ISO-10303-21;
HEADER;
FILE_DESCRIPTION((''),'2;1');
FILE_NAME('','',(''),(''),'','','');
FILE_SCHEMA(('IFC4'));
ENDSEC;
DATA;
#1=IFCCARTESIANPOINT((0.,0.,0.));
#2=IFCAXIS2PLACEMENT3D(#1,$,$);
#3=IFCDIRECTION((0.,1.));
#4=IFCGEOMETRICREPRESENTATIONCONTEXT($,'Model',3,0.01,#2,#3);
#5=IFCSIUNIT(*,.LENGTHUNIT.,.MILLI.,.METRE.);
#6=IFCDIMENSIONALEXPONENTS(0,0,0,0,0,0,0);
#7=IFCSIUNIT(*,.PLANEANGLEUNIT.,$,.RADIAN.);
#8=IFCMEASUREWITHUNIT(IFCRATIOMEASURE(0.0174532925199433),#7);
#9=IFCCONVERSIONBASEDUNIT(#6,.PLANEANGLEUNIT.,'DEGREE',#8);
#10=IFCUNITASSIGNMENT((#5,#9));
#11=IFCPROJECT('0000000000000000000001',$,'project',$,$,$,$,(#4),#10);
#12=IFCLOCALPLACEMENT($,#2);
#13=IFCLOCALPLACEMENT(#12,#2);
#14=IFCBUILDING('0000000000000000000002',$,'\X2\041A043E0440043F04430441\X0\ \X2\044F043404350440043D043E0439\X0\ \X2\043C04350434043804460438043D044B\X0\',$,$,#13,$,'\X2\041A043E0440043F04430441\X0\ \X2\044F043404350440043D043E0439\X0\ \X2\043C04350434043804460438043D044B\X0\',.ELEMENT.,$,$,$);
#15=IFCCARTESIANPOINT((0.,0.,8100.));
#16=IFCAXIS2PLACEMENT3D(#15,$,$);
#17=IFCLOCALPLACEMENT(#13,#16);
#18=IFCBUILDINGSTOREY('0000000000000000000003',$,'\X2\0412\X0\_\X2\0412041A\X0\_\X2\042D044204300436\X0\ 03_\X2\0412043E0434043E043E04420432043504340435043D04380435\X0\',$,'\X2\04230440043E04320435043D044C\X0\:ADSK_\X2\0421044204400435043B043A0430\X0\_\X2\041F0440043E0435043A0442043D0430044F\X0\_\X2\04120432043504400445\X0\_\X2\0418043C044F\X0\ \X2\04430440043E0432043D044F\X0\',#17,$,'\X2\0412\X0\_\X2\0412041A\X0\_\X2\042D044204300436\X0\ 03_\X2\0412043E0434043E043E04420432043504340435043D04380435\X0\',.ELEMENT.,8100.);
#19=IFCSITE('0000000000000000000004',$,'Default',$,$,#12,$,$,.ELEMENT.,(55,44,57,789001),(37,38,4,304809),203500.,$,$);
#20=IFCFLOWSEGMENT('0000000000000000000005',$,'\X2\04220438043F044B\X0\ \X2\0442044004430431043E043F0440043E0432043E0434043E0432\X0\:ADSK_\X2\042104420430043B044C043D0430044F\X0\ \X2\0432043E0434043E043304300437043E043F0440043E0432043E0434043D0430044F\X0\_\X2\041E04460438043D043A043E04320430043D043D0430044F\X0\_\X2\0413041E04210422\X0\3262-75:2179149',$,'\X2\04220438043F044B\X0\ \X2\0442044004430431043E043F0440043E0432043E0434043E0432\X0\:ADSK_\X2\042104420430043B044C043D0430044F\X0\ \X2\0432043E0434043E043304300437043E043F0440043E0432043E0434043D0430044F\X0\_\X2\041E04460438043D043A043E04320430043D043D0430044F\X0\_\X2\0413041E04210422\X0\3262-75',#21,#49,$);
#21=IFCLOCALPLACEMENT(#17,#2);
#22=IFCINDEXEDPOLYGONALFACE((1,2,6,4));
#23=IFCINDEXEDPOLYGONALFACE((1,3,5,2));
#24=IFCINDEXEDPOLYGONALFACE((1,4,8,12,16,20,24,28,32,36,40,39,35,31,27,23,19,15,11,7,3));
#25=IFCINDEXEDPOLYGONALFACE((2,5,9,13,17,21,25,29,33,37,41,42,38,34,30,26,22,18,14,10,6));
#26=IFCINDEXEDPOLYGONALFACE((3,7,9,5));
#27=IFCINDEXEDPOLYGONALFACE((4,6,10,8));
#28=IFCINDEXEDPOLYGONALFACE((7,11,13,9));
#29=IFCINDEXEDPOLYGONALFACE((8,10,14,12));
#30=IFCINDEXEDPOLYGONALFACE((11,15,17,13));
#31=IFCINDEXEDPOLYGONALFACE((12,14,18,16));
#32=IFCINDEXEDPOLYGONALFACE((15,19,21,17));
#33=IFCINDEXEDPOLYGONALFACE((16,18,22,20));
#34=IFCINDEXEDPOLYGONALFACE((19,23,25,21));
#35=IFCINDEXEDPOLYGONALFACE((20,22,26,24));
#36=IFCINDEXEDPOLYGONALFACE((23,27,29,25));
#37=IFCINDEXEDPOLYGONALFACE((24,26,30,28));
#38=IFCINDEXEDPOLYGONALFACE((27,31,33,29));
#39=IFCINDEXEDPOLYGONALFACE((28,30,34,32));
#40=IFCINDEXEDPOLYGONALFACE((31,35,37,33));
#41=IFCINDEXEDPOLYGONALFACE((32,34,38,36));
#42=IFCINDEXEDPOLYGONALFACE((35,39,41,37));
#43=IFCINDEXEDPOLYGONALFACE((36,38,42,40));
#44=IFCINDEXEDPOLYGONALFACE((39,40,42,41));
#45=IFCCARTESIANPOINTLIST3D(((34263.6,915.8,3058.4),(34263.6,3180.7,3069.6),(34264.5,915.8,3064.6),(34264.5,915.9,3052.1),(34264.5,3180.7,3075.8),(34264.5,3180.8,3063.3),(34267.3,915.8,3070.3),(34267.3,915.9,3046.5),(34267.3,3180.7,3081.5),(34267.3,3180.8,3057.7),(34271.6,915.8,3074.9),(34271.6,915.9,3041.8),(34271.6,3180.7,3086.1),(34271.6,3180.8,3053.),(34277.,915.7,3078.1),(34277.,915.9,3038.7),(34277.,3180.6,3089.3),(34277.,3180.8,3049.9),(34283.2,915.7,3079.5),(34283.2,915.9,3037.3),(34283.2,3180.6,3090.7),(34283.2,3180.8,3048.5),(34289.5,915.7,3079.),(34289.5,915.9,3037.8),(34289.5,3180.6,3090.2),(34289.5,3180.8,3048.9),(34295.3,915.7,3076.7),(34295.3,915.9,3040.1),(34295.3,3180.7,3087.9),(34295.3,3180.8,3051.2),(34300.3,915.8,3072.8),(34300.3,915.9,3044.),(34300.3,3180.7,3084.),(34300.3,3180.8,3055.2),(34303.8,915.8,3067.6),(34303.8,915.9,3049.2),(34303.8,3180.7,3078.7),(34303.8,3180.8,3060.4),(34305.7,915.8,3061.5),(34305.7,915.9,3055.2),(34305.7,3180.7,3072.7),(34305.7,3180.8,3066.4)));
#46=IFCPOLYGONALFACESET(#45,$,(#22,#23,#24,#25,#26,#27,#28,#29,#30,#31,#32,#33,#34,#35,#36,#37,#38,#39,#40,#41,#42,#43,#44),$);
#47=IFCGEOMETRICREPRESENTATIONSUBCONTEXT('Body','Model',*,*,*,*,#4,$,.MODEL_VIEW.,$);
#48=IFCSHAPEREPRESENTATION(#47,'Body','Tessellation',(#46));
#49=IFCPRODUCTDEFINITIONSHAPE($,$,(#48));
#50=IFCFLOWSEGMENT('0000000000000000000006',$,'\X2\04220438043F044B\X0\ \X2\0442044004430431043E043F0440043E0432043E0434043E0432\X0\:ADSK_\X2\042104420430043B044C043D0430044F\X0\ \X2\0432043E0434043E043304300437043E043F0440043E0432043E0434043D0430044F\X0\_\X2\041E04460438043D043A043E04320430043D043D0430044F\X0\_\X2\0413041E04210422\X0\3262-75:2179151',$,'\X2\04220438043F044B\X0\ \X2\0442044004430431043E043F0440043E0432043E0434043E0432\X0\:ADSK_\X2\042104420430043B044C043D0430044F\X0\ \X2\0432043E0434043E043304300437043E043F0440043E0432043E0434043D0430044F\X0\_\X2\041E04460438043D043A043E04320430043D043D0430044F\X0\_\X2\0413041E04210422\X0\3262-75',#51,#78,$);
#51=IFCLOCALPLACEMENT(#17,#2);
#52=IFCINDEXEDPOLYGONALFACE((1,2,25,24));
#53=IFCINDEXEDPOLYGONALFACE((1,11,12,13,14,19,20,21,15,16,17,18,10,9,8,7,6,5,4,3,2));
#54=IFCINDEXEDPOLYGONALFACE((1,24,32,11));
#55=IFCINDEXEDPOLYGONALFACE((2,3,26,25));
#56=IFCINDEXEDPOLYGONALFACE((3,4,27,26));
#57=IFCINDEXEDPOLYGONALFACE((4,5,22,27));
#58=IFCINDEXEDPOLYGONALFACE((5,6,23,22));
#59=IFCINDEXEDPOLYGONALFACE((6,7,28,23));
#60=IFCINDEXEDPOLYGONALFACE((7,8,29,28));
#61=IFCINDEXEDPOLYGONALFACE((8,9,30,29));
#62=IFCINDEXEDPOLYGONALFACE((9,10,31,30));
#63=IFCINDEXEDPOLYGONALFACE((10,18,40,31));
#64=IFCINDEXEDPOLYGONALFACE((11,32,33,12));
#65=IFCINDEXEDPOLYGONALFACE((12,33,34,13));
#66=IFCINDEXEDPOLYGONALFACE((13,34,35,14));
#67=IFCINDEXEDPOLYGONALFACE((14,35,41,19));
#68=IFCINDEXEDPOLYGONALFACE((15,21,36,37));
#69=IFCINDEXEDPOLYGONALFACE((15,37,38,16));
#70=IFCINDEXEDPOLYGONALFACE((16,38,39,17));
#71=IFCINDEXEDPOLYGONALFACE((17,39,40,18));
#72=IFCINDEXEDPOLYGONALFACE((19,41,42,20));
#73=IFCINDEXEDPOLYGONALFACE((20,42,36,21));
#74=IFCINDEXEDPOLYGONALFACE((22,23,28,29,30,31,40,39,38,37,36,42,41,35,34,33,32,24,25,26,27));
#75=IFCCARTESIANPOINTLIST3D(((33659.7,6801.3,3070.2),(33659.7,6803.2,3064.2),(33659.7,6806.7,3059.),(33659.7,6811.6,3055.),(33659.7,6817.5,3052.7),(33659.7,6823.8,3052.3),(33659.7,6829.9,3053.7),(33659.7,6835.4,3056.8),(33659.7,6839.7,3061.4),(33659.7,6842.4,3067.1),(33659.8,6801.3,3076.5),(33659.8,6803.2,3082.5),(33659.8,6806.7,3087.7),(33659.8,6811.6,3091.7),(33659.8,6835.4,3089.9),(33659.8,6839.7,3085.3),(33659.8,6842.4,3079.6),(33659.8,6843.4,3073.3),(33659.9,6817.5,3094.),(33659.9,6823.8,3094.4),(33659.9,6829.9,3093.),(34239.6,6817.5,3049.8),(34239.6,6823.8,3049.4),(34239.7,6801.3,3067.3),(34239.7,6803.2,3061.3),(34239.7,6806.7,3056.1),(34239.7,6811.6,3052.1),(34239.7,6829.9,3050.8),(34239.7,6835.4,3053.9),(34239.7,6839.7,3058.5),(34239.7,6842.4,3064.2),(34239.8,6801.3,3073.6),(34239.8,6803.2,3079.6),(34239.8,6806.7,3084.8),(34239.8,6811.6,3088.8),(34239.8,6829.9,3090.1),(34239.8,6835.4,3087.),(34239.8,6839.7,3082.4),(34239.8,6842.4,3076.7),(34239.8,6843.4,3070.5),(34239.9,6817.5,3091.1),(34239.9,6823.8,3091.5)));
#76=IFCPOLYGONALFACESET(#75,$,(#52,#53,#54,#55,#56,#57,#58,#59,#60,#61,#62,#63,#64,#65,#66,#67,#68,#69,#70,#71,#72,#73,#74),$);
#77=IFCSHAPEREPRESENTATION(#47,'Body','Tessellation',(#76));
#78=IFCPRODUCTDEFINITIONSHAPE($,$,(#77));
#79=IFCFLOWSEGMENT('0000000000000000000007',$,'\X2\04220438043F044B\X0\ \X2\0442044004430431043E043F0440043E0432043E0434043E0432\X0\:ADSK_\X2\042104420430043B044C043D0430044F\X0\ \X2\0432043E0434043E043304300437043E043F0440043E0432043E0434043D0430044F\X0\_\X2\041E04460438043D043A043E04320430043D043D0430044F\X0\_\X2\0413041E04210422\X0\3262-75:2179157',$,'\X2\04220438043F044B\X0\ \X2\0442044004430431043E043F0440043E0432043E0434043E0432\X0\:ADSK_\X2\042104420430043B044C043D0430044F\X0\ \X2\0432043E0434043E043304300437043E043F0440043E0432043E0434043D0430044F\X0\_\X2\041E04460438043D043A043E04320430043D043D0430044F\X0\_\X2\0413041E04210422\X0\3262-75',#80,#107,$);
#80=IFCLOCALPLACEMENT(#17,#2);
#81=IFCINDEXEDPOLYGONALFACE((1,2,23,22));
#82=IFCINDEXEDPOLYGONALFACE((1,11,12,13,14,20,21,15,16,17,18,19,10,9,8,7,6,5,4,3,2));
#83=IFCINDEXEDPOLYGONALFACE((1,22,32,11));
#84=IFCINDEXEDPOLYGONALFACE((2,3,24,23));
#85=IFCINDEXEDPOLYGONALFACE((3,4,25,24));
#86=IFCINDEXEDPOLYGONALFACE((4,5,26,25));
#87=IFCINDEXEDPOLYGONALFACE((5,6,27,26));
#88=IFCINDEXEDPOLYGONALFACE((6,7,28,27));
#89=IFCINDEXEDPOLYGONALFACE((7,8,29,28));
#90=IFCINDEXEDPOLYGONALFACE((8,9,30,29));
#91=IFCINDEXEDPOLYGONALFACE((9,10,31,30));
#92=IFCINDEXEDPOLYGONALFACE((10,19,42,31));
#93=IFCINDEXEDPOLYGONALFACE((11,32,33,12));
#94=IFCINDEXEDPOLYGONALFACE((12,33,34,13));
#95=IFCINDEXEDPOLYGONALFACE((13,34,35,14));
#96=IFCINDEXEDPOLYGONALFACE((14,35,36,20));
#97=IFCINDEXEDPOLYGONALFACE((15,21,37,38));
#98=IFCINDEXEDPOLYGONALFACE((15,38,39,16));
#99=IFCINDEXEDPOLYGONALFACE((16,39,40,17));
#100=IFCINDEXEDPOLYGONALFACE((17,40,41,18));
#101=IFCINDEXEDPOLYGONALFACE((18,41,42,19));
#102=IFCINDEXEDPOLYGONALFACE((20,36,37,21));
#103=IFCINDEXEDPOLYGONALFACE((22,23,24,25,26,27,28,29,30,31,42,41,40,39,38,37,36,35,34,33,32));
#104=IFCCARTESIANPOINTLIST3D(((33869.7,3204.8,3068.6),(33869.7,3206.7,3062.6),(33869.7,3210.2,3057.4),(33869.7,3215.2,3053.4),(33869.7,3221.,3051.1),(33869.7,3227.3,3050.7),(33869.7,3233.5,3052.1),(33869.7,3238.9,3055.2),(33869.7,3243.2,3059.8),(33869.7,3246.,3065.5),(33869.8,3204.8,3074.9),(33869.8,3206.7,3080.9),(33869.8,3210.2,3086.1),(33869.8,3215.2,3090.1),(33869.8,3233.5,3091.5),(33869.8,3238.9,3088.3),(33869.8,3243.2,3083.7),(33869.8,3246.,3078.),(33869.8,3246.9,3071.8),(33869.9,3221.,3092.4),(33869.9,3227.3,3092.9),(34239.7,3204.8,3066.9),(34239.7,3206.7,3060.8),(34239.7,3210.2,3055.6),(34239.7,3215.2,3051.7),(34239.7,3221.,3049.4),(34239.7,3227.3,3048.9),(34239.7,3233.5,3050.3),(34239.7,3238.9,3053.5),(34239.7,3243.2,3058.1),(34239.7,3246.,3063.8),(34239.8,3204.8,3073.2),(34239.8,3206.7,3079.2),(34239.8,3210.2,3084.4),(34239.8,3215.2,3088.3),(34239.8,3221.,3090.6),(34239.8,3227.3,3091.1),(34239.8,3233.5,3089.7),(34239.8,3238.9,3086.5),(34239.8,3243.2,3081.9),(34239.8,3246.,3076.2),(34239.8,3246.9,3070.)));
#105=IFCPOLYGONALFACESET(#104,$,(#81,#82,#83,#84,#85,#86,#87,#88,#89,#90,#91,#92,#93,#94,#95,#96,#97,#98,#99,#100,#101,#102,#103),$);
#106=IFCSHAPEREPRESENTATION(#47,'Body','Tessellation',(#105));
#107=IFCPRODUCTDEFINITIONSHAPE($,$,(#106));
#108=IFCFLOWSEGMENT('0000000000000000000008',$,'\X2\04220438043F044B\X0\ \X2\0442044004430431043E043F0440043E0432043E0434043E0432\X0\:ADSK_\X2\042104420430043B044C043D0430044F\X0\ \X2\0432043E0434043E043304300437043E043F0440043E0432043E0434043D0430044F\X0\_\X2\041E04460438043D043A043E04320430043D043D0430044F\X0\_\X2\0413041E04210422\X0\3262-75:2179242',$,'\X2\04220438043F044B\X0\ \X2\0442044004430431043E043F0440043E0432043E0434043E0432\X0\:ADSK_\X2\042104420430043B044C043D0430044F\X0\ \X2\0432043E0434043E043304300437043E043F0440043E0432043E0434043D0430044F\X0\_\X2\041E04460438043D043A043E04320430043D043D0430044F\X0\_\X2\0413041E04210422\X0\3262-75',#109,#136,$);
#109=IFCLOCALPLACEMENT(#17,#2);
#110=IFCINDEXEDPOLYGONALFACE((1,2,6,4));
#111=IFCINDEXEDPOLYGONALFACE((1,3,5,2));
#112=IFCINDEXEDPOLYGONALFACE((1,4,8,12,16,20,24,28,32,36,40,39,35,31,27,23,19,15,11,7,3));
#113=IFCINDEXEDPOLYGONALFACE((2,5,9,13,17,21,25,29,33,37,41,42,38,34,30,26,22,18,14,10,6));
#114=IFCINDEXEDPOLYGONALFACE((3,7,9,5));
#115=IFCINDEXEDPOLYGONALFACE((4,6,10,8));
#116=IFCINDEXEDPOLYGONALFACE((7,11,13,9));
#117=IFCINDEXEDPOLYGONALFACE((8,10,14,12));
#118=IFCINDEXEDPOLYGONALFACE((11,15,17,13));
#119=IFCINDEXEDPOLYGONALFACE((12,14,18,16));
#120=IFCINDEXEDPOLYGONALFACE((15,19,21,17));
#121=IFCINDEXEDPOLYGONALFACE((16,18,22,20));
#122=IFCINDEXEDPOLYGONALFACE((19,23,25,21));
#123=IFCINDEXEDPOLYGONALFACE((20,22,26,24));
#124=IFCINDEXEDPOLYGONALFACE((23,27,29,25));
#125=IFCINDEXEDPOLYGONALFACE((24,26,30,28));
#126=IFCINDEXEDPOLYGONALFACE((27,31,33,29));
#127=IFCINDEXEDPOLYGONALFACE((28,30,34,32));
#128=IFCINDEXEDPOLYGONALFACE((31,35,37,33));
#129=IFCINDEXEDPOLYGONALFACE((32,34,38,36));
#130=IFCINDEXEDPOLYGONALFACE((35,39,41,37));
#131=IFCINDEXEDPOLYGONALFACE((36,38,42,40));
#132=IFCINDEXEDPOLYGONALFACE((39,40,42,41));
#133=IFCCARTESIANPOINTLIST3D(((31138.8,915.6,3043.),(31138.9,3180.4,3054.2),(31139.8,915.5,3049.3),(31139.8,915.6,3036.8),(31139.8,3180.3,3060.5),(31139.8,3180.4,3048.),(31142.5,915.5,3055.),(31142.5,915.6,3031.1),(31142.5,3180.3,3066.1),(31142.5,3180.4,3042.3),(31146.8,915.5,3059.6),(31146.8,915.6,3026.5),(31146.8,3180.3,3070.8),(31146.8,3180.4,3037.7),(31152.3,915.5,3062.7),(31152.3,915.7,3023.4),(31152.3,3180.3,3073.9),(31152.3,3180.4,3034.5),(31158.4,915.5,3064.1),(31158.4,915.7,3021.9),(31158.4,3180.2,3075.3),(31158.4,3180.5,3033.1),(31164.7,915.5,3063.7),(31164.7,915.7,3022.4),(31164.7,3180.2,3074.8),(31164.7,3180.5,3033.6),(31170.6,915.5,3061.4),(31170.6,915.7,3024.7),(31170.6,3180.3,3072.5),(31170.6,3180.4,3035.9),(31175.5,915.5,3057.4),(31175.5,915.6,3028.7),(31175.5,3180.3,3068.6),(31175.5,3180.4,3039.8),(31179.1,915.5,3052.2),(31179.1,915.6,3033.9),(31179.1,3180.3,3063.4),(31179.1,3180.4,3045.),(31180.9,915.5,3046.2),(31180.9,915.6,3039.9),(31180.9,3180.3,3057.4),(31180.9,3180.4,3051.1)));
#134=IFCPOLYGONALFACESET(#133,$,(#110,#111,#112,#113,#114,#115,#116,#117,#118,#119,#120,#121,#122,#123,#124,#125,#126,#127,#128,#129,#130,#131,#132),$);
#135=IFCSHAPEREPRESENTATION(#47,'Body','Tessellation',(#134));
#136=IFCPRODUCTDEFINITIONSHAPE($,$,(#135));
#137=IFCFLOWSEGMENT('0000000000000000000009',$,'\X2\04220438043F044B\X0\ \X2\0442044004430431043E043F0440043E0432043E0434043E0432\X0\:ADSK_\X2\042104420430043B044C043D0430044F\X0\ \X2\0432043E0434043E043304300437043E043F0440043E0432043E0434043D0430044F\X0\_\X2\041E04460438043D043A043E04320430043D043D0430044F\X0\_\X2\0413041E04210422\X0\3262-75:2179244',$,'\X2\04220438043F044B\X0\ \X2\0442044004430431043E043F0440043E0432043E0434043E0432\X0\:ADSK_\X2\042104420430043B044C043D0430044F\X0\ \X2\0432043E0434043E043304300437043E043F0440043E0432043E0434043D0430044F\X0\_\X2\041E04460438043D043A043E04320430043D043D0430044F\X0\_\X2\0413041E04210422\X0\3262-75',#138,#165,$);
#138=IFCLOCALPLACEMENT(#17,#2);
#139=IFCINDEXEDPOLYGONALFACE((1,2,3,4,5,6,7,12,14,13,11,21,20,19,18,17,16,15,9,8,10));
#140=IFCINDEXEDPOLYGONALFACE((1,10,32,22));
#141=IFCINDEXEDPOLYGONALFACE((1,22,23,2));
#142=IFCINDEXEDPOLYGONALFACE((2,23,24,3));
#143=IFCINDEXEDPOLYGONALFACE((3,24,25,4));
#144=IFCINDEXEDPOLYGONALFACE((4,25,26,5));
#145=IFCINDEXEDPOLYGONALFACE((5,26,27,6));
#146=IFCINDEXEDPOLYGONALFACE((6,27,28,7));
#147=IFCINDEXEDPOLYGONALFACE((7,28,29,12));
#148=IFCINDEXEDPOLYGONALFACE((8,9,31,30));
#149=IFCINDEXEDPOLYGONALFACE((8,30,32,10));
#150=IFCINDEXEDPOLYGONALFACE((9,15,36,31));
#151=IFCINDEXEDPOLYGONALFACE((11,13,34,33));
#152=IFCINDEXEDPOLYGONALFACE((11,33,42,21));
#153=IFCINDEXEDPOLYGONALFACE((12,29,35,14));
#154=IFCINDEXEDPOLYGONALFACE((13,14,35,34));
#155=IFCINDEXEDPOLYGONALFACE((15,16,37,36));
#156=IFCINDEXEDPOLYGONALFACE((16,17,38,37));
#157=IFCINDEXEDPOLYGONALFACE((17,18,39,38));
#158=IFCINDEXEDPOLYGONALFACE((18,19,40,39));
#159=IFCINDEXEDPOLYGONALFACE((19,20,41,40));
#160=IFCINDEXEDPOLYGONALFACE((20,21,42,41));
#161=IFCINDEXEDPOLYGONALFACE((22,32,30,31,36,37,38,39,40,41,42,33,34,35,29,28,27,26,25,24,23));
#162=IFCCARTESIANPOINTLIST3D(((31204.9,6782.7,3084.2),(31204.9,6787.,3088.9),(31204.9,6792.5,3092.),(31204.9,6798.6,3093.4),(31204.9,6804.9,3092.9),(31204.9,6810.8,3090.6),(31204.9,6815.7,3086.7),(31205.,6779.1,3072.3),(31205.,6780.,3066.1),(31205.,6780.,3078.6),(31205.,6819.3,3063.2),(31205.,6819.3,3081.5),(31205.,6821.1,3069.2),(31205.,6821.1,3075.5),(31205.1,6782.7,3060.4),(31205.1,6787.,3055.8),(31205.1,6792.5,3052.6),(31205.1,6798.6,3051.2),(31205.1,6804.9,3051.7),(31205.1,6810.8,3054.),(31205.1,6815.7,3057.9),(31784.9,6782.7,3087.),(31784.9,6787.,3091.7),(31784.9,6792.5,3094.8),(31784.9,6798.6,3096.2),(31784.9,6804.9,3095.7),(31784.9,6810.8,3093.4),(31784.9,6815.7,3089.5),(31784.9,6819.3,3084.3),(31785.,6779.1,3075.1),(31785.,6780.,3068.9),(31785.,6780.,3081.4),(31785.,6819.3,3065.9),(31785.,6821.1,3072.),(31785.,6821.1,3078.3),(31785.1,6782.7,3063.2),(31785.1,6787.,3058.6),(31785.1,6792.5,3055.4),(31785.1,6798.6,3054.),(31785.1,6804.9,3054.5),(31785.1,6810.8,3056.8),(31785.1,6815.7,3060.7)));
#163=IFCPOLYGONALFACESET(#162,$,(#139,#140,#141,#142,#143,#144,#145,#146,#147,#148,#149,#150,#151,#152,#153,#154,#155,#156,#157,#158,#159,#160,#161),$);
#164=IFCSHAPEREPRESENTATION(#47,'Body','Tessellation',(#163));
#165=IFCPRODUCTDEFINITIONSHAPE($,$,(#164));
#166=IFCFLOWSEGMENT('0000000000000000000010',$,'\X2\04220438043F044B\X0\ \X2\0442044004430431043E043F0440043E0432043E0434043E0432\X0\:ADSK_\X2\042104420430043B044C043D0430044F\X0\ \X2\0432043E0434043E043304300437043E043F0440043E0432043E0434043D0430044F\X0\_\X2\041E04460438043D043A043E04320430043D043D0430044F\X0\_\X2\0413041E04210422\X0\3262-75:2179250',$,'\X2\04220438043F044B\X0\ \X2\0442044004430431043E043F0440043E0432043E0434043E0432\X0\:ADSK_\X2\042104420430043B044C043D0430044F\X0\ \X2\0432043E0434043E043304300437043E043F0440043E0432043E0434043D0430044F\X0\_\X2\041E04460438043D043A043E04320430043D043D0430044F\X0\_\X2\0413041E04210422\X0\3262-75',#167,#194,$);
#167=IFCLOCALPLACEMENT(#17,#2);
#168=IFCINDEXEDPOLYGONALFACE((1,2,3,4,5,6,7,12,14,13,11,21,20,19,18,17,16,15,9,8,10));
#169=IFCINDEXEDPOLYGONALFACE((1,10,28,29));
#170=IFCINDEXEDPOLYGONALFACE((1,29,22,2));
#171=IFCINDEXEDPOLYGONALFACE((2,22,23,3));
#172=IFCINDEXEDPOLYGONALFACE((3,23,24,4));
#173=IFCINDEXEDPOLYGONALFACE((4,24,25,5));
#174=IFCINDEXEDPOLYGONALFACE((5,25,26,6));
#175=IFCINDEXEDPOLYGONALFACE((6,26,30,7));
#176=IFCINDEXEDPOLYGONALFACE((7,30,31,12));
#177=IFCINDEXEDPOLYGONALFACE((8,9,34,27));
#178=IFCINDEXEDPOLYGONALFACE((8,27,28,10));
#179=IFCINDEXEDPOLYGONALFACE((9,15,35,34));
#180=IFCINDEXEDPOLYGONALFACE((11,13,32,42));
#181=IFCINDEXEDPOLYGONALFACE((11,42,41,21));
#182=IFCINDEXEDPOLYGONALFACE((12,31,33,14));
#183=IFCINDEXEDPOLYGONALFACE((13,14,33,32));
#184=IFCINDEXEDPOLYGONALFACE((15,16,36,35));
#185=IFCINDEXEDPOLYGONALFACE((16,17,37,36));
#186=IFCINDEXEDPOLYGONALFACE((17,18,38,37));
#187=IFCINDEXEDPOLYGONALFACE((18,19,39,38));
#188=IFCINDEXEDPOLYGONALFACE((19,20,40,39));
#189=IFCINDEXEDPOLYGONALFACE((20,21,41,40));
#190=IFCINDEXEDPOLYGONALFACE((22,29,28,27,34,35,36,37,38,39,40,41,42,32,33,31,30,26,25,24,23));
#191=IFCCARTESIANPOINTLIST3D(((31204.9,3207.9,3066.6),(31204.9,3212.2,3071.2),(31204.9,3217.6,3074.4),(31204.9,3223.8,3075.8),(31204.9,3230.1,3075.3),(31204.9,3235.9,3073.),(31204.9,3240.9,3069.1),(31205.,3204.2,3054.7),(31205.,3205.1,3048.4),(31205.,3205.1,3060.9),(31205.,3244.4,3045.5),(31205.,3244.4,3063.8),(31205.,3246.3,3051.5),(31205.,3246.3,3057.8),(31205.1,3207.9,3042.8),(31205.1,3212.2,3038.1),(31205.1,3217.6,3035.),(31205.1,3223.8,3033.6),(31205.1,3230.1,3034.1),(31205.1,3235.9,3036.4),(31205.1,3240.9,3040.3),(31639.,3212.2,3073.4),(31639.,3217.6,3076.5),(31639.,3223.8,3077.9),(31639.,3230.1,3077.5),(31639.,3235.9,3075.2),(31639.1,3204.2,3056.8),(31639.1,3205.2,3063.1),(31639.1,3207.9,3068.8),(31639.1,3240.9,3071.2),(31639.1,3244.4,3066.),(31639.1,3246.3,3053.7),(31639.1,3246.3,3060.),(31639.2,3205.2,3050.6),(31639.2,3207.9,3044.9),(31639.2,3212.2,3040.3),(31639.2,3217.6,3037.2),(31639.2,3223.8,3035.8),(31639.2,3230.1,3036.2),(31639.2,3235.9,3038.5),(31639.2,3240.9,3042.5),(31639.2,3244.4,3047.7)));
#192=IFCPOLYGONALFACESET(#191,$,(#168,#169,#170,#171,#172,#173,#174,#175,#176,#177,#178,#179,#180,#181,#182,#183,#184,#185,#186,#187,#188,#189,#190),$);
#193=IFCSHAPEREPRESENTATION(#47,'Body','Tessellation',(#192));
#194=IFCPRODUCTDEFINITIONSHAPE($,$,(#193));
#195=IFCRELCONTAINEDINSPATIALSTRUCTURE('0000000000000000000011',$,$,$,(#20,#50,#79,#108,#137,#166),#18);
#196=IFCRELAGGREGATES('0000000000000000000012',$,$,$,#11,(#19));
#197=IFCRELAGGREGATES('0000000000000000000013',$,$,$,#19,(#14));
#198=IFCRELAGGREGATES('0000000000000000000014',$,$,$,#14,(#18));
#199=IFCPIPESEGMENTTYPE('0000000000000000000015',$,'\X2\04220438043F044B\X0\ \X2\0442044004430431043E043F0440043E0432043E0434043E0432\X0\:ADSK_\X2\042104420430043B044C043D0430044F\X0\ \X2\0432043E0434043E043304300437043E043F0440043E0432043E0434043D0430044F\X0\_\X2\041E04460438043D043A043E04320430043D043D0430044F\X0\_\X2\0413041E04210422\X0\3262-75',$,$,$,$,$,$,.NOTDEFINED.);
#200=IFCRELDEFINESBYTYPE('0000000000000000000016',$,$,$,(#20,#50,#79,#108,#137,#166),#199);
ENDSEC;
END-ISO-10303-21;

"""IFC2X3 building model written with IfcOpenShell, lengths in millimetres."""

from ifc_helpers import new_model, entity, si_unit, converted_unit, direction, frame, origin, origin_2d_with_axis, place, context, subcontext, project, spatial, circle, extrude, type_object, element, save


model = new_model("IFC2X3")

# Units and contexts
model_context = context("Model", 3, precision=0.01, world=origin(), true_north=direction((0.0, 1.0)))
body_context = subcontext(model_context, "Body", "Model", "MODEL_VIEW")
ifc_project = project(units=[si_unit("LENGTHUNIT", "METRE", prefix="MILLI"), converted_unit("PLANEANGLEUNIT", "DEGREE", entity("IfcRatioMeasure", 0.0174532925199433), si_unit("PLANEANGLEUNIT", "RADIAN"), dimensions=[0, 0, 0, 0, 0, 0, 0])], contexts=[model_context])

# Site, building, storey
site_placement = place(None, origin())
site = spatial("IfcSite", under=ifc_project, at=site_placement, Name="Default", CompositionType="ELEMENT", RefLatitude=(55, 44, 57, 789001), RefLongitude=(37, 38, 4, 304809), RefElevation=203500.0)
building_placement = place(site_placement, origin())
building = spatial("IfcBuilding", under=site, at=building_placement, Name="Корпус ядерной медицины", LongName="Корпус ядерной медицины", CompositionType="ELEMENT")
storey_placement = place(building_placement, frame((0.0, 0.0, 8100.0)))
storey = spatial("IfcBuildingStorey", under=building, at=storey_placement, Name="В_ВК_Этаж 03_Водоотведение", ObjectType="Уровень:ADSK_Стрелка_Проектная_Вверх_Имя уровня", LongName="В_ВК_Этаж 03_Водоотведение", CompositionType="ELEMENT", Elevation=8100.0)

# Flow segments
pipe_segment_type_1 = type_object("IfcPipeSegmentType", Name="Типы трубопроводов:ADSK_Стальная водогазопроводная_Оцинкованная_ГОСТ3262-75", PredefinedType="NOTDEFINED")
flow_segment_1_placement = place(storey_placement, frame((34262.0, 915.7, 3035.6)))
element("IfcFlowSegment", 1, at=flow_segment_1_placement, inside=storey, type_object=pipe_segment_type_1, Name="Типы трубопроводов:ADSK_Стальная водогазопроводная_Оцинкованная_ГОСТ3262-75:2179149", ObjectType="Типы трубопроводов:ADSK_Стальная водогазопроводная_Оцинкованная_ГОСТ3262-75", context=body_context, shape_type="SweptSolid", body=[
    extrude(circle(Radius=21.1, at=origin_2d_with_axis()), frame((22.8, 0.1, 22.8), z_axis=(0.0, 0.999988, 0.004938), x_axis=(-1.0, 0.0, 0.0)), (0.0, 0.0, 1.0), 2264.9),
])
flow_segment_2_placement = place(storey_placement, frame((33659.7, 6799.5, 3047.7)))
element("IfcFlowSegment", 2, at=flow_segment_2_placement, inside=storey, type_object=pipe_segment_type_1, Name="Типы трубопроводов:ADSK_Стальная водогазопроводная_Оцинкованная_ГОСТ3262-75:2179151", ObjectType="Типы трубопроводов:ADSK_Стальная водогазопроводная_Оцинкованная_ГОСТ3262-75", context=body_context, shape_type="SweptSolid", body=[
    extrude(circle(Radius=21.1, at=origin_2d_with_axis()), frame((580.1, 22.8, 22.8), z_axis=(-0.999988, 0.0, 0.005), x_axis=(0.0, 1.0, 0.0)), (0.0, 0.0, 1.0), 580.0),
])
flow_segment_3_placement = place(storey_placement, frame((33869.7, 3203.0, 3047.3)))
element("IfcFlowSegment", 3, at=flow_segment_3_placement, inside=storey, type_object=pipe_segment_type_1, Name="Типы трубопроводов:ADSK_Стальная водогазопроводная_Оцинкованная_ГОСТ3262-75:2179157", ObjectType="Типы трубопроводов:ADSK_Стальная водогазопроводная_Оцинкованная_ГОСТ3262-75", context=body_context, shape_type="SweptSolid", body=[
    extrude(circle(Radius=21.1, at=origin_2d_with_axis()), frame((370.1, 22.8, 22.8), z_axis=(-0.999989, 0.0, 0.004736), x_axis=(0.0, 1.0, 0.0)), (0.0, 0.0, 1.0), 370.0),
])
flow_segment_4_placement = place(storey_placement, frame((31137.2, 915.5, 3020.3)))
element("IfcFlowSegment", 4, at=flow_segment_4_placement, inside=storey, type_object=pipe_segment_type_1, Name="Типы трубопроводов:ADSK_Стальная водогазопроводная_Оцинкованная_ГОСТ3262-75:2179242", ObjectType="Типы трубопроводов:ADSK_Стальная водогазопроводная_Оцинкованная_ГОСТ3262-75", context=body_context, shape_type="SweptSolid", body=[
    extrude(circle(Radius=21.1, at=origin_2d_with_axis()), frame((22.8, 0.1, 22.8), z_axis=(0.0, 0.999988, 0.004938), x_axis=(-1.0, 0.0, 0.0)), (0.0, 0.0, 1.0), 2264.8),
])
flow_segment_5_placement = place(storey_placement, frame((31204.9, 6777.5, 3049.6)))
element("IfcFlowSegment", 5, at=flow_segment_5_placement, inside=storey, type_object=pipe_segment_type_1, Name="Типы трубопроводов:ADSK_Стальная водогазопроводная_Оцинкованная_ГОСТ3262-75:2179244", ObjectType="Типы трубопроводов:ADSK_Стальная водогазопроводная_Оцинкованная_ГОСТ3262-75", context=body_context, shape_type="SweptSolid", body=[
    extrude(circle(Radius=21.1, at=origin_2d_with_axis()), frame((0.1, 22.8, 22.8), z_axis=(0.999988, 0.0, 0.004813), x_axis=(0.0, -1.0, 0.0)), (0.0, 0.0, 1.0), 580.0),
])
flow_segment_6_placement = place(storey_placement, frame((31204.9, 3202.6, 3031.9)))
element("IfcFlowSegment", 6, at=flow_segment_6_placement, inside=storey, type_object=pipe_segment_type_1, Name="Типы трубопроводов:ADSK_Стальная водогазопроводная_Оцинкованная_ГОСТ3262-75:2179250", ObjectType="Типы трубопроводов:ADSK_Стальная водогазопроводная_Оцинкованная_ГОСТ3262-75", context=body_context, shape_type="SweptSolid", body=[
    extrude(circle(Radius=21.1, at=origin_2d_with_axis()), frame((0.1, 22.8, 22.8), z_axis=(0.999987, 0.000005, 0.005), x_axis=(0.000005, -1.0, 0.0)), (0.0, 0.0, 1.0), 434.1),
])

save(model, "model.ifc")
